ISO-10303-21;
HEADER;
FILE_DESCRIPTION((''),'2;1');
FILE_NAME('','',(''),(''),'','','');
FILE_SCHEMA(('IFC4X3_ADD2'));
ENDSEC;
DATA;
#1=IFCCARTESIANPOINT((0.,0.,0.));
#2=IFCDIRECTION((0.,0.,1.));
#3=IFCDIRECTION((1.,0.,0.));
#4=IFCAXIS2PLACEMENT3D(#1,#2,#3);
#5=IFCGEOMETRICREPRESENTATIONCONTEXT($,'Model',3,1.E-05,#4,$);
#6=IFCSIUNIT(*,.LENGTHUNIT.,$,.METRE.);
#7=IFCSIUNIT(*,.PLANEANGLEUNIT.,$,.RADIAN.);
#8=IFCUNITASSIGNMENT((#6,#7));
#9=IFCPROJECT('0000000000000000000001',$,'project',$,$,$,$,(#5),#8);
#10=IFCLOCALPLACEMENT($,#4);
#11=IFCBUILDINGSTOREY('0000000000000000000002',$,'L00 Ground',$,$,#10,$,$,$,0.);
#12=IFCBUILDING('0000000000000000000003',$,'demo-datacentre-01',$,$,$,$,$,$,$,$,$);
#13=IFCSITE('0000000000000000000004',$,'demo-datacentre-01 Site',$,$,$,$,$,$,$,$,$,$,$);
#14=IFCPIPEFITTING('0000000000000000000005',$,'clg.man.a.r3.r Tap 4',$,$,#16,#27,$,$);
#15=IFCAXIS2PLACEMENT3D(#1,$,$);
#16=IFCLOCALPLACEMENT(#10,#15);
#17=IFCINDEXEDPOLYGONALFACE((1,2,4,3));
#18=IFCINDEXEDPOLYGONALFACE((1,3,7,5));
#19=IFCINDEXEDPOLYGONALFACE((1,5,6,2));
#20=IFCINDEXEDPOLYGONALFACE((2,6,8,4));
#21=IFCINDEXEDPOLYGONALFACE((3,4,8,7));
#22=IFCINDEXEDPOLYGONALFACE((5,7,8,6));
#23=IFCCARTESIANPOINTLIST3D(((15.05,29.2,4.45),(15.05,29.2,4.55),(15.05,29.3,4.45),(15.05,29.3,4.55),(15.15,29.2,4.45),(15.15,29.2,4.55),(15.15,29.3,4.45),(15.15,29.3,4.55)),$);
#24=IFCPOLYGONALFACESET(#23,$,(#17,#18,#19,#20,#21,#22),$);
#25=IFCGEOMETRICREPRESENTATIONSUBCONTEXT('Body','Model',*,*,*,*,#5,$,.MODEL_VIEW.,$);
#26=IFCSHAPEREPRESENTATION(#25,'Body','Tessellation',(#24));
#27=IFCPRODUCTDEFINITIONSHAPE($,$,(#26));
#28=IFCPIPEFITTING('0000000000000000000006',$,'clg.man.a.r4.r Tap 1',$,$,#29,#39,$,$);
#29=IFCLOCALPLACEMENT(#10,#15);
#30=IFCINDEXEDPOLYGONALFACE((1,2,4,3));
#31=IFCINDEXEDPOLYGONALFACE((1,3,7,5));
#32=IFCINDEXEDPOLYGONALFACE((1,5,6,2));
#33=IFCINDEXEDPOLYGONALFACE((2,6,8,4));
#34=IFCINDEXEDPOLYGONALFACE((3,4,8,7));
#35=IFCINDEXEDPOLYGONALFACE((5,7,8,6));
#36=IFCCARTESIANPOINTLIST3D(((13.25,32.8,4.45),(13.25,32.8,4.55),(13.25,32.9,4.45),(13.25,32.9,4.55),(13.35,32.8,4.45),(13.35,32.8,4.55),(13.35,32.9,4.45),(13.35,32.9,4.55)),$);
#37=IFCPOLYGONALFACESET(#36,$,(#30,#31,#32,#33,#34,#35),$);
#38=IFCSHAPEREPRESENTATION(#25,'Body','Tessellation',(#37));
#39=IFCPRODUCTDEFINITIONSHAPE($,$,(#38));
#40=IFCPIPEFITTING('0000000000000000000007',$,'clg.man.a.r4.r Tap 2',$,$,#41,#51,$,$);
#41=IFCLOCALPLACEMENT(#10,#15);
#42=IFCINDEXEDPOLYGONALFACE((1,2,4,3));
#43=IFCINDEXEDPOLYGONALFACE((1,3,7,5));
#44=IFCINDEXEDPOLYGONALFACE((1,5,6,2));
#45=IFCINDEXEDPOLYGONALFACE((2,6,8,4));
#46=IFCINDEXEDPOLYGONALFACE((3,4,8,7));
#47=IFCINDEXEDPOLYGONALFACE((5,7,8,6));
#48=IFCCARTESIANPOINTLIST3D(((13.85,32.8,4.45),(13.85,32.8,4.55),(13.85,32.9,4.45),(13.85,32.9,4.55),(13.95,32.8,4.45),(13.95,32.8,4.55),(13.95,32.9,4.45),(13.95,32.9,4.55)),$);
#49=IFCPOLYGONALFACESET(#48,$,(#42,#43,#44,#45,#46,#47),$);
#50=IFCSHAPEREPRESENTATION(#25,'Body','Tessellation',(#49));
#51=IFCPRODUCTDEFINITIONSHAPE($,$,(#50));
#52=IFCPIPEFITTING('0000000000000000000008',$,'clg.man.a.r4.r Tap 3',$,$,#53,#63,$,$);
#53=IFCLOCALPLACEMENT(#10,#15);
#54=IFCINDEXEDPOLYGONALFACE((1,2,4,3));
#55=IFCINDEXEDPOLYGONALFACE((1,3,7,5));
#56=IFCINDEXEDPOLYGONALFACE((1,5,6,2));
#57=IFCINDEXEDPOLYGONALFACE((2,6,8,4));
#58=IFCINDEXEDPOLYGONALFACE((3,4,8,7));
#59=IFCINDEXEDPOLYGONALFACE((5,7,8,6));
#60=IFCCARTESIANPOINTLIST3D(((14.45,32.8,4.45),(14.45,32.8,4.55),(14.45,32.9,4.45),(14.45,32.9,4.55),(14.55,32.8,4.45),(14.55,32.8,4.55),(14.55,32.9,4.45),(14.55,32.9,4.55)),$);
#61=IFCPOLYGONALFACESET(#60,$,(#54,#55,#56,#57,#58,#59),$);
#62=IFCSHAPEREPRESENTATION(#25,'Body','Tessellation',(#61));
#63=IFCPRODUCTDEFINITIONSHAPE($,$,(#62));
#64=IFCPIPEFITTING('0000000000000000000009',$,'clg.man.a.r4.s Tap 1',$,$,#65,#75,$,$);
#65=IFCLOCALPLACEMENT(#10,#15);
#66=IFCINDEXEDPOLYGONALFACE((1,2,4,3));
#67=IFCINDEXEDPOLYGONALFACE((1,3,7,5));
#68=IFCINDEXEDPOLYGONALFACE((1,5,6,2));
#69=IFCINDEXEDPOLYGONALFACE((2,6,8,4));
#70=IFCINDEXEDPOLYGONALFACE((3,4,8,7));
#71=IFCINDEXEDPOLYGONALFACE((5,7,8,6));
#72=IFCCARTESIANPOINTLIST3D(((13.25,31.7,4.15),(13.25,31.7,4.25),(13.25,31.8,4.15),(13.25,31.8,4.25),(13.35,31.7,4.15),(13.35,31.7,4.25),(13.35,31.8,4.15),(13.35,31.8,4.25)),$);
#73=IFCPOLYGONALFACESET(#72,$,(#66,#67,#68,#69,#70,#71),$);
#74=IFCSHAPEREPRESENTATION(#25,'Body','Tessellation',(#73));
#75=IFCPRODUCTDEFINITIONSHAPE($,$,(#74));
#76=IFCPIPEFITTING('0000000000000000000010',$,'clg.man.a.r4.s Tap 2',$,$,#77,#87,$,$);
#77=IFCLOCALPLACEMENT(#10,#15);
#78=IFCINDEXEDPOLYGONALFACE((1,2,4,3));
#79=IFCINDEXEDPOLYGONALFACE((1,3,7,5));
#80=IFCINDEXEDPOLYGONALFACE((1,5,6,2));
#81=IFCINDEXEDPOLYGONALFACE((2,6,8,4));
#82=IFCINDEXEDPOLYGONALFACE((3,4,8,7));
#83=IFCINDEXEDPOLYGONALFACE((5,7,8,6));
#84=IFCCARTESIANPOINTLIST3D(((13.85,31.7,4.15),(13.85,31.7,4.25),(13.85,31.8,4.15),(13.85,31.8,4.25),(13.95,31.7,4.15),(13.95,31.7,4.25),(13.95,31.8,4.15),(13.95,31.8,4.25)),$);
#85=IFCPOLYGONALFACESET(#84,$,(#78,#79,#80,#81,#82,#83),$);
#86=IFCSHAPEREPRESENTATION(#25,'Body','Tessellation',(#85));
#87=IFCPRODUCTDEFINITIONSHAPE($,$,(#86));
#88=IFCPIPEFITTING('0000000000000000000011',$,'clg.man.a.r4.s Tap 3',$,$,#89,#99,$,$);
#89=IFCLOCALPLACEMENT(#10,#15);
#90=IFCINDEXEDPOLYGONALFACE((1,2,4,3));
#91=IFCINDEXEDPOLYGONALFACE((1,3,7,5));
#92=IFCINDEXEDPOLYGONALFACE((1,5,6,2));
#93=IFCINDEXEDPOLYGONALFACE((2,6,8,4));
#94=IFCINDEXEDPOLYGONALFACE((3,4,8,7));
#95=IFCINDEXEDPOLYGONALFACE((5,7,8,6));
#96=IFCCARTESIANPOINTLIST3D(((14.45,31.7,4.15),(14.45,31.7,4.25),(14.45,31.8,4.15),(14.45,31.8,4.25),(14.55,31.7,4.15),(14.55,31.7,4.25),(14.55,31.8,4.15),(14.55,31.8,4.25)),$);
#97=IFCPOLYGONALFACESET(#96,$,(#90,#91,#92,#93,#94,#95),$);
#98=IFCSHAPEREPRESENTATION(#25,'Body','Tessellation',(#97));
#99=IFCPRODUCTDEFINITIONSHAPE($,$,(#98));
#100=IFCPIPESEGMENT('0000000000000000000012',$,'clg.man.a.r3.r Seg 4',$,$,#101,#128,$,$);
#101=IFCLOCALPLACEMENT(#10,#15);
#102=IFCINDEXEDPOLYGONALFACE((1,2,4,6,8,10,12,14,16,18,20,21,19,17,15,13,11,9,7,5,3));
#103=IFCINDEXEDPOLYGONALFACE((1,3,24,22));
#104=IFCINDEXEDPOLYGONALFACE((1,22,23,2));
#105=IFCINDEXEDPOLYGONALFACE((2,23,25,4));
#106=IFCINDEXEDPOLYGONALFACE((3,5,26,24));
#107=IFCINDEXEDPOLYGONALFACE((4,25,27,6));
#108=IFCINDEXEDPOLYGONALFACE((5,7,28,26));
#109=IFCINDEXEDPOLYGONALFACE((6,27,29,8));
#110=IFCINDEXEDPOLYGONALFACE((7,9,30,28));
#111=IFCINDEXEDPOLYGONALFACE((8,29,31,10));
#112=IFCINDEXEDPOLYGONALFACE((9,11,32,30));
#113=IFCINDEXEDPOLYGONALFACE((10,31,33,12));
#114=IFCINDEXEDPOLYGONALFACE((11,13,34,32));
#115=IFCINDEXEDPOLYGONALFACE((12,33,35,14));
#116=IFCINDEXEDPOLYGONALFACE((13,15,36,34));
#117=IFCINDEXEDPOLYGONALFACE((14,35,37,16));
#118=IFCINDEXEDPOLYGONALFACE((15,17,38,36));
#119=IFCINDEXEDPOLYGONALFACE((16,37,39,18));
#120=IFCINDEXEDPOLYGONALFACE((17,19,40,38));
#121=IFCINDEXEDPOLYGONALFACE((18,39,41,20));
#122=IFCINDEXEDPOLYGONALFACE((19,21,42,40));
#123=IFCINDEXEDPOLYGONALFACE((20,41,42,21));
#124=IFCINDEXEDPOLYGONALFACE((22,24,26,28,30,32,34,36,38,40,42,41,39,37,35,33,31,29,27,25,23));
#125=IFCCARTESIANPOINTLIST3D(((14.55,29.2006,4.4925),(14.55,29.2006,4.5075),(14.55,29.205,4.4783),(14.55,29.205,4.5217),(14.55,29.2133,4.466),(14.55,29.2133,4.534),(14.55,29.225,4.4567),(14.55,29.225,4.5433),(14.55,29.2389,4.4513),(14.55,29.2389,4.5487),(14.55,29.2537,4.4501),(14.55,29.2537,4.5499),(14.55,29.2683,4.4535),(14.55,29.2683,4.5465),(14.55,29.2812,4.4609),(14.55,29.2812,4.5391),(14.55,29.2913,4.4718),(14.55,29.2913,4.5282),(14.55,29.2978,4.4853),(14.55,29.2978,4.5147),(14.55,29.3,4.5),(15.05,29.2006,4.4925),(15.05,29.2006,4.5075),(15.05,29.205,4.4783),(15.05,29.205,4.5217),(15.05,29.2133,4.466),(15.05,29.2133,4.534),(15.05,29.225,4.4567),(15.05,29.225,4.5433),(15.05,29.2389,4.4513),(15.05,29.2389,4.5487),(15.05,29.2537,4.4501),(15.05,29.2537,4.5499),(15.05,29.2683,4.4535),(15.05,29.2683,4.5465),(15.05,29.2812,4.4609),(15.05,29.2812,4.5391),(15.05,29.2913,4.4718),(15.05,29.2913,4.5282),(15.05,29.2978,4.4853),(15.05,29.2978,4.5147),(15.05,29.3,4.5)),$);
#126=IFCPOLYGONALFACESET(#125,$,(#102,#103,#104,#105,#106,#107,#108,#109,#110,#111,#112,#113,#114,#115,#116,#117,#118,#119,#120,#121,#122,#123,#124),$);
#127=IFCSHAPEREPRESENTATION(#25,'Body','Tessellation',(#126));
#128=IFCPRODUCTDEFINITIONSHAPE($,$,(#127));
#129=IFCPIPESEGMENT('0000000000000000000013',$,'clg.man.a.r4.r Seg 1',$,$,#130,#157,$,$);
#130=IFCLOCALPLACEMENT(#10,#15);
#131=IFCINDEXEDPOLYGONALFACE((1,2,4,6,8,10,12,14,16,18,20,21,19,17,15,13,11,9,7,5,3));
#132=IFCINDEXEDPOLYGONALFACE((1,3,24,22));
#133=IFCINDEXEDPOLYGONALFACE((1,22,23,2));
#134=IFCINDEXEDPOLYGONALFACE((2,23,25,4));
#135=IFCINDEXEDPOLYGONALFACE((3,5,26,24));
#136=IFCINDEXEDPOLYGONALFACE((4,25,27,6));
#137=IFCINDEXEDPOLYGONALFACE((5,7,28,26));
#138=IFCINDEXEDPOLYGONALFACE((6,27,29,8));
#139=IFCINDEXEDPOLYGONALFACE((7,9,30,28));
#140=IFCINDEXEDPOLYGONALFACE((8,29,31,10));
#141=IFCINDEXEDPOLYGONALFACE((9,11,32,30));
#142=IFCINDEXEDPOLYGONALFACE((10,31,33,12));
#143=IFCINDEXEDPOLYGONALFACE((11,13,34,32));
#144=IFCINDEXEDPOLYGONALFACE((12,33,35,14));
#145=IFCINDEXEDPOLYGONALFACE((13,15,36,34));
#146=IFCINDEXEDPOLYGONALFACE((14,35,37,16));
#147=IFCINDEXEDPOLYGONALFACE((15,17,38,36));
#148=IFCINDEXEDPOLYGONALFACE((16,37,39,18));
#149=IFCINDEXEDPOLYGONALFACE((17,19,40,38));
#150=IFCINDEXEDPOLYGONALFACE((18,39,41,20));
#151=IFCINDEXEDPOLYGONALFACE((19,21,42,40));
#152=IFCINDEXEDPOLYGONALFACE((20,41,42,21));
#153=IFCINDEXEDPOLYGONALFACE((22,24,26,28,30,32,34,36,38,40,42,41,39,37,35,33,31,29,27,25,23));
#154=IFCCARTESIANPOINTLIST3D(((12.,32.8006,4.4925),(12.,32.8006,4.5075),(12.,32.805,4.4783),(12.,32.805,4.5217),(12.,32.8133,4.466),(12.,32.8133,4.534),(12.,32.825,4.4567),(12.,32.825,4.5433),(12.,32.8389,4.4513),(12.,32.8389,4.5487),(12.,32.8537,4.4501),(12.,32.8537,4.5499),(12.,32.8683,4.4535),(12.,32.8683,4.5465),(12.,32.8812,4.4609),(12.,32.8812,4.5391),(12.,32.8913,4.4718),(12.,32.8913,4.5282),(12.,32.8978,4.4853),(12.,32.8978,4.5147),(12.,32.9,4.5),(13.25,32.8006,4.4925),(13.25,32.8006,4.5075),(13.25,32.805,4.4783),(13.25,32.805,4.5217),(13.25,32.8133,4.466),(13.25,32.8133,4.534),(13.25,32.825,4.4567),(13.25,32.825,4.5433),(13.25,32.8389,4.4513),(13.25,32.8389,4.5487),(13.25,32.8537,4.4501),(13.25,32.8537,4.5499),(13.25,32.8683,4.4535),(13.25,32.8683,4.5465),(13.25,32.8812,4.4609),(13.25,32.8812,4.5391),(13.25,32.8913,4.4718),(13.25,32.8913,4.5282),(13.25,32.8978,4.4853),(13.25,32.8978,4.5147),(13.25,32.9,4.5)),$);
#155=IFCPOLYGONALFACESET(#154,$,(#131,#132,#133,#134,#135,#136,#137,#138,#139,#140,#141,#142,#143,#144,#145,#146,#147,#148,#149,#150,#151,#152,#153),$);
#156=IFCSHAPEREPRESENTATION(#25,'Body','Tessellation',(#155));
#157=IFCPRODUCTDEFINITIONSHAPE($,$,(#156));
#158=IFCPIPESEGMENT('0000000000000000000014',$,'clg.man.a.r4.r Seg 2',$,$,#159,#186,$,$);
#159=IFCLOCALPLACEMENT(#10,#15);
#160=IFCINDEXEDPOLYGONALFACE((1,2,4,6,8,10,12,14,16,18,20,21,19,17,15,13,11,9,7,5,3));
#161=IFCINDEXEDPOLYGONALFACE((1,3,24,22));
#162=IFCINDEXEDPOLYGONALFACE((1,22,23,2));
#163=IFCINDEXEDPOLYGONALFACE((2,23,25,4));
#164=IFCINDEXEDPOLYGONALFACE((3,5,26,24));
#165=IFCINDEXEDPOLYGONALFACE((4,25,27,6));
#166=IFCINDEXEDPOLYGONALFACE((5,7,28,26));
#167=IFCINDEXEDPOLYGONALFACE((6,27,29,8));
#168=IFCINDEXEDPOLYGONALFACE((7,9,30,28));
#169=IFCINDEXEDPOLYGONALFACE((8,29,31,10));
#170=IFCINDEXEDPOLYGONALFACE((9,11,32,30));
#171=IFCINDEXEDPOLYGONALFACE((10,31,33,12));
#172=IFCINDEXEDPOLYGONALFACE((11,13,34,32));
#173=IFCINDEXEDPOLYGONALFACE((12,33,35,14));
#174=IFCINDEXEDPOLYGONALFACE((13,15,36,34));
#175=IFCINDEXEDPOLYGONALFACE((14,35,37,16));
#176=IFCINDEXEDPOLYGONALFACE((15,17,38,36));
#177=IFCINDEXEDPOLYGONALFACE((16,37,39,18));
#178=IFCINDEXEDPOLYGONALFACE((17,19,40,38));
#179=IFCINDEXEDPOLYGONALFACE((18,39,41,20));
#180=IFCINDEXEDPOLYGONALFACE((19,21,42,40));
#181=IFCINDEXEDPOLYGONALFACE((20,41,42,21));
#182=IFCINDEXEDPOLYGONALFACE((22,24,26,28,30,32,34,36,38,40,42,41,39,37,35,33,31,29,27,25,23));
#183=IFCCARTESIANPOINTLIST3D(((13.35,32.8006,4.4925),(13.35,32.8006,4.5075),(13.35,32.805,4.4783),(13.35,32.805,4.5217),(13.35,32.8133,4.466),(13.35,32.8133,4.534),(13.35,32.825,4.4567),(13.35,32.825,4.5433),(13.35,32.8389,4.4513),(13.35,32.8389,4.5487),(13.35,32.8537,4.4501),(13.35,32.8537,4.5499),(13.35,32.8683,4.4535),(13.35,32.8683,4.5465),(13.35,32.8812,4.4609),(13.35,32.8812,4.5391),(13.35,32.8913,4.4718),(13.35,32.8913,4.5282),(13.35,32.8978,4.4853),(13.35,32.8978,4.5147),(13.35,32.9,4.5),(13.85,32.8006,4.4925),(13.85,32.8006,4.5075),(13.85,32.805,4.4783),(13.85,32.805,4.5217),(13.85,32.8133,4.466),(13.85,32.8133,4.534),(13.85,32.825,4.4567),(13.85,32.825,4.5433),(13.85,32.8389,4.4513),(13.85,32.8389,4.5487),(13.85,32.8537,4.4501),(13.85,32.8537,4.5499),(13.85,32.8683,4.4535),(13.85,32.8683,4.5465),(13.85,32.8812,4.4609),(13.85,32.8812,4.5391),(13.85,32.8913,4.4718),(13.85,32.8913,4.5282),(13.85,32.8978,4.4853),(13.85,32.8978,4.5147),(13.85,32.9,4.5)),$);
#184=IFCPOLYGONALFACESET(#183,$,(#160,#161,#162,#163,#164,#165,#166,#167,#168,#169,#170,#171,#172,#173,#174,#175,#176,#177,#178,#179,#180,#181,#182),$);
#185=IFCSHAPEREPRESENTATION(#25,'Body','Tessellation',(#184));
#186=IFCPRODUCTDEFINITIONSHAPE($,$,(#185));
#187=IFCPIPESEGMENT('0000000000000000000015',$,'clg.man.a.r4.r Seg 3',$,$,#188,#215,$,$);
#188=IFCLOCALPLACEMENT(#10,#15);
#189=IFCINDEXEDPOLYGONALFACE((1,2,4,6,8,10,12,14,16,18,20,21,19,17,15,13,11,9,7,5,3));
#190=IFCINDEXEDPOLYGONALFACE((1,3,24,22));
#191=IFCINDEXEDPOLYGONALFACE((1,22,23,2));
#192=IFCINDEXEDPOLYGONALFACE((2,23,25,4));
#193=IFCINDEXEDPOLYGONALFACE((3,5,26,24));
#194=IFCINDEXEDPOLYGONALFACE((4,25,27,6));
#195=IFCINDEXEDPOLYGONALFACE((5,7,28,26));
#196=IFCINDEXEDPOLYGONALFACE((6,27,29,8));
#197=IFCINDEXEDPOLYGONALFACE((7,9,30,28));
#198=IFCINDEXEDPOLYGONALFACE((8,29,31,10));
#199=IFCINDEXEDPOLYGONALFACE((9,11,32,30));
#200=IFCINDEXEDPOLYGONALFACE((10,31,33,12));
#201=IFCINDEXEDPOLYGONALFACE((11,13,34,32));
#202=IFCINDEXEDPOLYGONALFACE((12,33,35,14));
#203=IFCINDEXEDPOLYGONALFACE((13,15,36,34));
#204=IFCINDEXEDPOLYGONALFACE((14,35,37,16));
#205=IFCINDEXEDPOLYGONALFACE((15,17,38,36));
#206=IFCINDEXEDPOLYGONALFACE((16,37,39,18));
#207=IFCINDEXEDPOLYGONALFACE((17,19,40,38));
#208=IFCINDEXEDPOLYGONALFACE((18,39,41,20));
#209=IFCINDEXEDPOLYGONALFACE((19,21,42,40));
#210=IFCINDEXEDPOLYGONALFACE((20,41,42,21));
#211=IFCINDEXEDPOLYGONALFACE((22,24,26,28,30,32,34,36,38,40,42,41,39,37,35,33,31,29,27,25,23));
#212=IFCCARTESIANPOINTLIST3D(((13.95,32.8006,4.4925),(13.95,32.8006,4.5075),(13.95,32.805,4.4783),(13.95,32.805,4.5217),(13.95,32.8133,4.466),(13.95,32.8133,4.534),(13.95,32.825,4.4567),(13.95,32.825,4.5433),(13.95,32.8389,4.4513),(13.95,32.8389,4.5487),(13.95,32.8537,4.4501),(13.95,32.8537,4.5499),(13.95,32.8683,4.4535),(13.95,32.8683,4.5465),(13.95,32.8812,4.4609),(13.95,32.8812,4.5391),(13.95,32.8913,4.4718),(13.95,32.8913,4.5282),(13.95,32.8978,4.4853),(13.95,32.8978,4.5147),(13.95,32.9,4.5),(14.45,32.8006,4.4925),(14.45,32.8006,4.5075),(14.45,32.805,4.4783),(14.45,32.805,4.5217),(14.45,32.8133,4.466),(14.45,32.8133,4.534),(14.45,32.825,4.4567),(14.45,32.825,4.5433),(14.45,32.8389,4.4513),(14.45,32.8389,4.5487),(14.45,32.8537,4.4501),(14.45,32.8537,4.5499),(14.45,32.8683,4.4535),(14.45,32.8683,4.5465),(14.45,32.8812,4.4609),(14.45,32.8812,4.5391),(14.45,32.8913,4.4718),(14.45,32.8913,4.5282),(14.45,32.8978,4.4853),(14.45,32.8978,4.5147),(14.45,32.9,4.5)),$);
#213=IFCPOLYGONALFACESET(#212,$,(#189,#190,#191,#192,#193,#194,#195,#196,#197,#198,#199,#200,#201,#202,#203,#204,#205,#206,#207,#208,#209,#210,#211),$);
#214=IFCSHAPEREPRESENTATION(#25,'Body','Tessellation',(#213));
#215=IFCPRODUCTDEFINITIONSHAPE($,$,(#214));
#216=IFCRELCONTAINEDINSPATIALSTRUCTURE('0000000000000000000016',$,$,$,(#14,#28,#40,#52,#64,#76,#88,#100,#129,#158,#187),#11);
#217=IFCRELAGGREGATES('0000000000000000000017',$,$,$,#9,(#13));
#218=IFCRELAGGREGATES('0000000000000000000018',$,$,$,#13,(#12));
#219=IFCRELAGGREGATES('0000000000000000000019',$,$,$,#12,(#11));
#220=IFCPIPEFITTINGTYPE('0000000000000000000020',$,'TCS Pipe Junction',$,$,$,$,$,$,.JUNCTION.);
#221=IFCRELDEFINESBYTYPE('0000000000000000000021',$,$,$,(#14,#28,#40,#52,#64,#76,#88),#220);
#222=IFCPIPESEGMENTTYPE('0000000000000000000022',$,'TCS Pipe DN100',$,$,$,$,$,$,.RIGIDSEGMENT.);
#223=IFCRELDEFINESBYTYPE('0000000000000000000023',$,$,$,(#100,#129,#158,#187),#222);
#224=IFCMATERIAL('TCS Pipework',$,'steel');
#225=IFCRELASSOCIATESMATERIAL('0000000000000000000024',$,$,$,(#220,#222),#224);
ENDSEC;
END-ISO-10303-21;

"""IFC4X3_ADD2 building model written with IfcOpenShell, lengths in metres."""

from ifc_helpers import new_model, si_unit, frame, origin_with_axes, place, context, subcontext, project, spatial, rectangle, circle, extrude, material, type_object, element, save


model = new_model("IFC4X3_ADD2")

# Units and contexts
model_context = context("Model", 3, precision=1e-05, world=origin_with_axes())
body_context = subcontext(model_context, "Body", "Model", "MODEL_VIEW")
ifc_project = project(units=[si_unit("LENGTHUNIT", "METRE"), si_unit("PLANEANGLEUNIT", "RADIAN")], contexts=[model_context])

# Site, building, storey
site = spatial("IfcSite", under=ifc_project, Name="demo-datacentre-01 Site")
building = spatial("IfcBuilding", under=site, Name="demo-datacentre-01")
storey_placement = place(None, origin_with_axes())
storey = spatial("IfcBuildingStorey", under=building, at=storey_placement, Name="L00 Ground", Elevation=0.0)

# Pipe fittings
ifc_material = material(Name="TCS Pipework", Category="steel")
pipe_fitting_type = type_object("IfcPipeFittingType", Name="TCS Pipe Junction", PredefinedType="JUNCTION", material=ifc_material)
for number, where, z_axis, x_axis, name in (
    (1, (15.1, 29.25, 4.45), (0.0, 0.0, 1.0), (1.0, 0.0, 0.0), "clg.man.a.r3.r Tap 4"),
    (2, (13.3, 32.85, 4.45), (0.0, 0.0, 1.0), (1.0, 0.0, 0.0), "clg.man.a.r4.r Tap 1"),
    (3, (13.9, 32.85, 4.45), (0.0, 0.0, 1.0), (1.0, 0.0, 0.0), "clg.man.a.r4.r Tap 2"),
    (4, (14.5, 32.85, 4.45), (0.0, 0.0, 1.0), (1.0, 0.0, 0.0), "clg.man.a.r4.r Tap 3"),
    (5, (13.3, 31.75, 4.15), (0.0, 0.0, 1.0), (1.0, 0.0, 0.0), "clg.man.a.r4.s Tap 1"),
    (6, (13.9, 31.75, 4.15), (0.0, 0.0, 1.0), (1.0, 0.0, 0.0), "clg.man.a.r4.s Tap 2"),
    (7, (14.5, 31.75, 4.15), (0.0, 0.0, 1.0), (1.0, 0.0, 0.0), "clg.man.a.r4.s Tap 3"),
):
    element("IfcPipeFitting", number, at=place(storey_placement, frame(where, z_axis=z_axis, x_axis=x_axis)), inside=storey, type_object=pipe_fitting_type, Name=name, context=body_context, shape_type="SweptSolid", body=[
        extrude(rectangle(XDim=0.1, YDim=0.1), origin_with_axes(), (0.0, 0.0, 1.0), 0.1),
    ])

# Pipe segments
pipe_segment_type_1 = type_object("IfcPipeSegmentType", Name="TCS Pipe DN100", PredefinedType="RIGIDSEGMENT", material=ifc_material)
pipe_segment_1_placement = place(storey_placement, frame((14.55, 29.25, 4.5), z_axis=(1.0, 0.0, 0.0), x_axis=(0.0, 1.0, 0.0)))
element("IfcPipeSegment", 8, at=pipe_segment_1_placement, inside=storey, type_object=pipe_segment_type_1, Name="clg.man.a.r3.r Seg 4", context=body_context, shape_type="SweptSolid", body=[
    extrude(circle(Radius=0.05), origin_with_axes(), (0.0, 0.0, 1.0), 0.5),
])
pipe_segment_2_placement = place(storey_placement, frame((12.0, 32.85, 4.5), z_axis=(1.0, 0.0, 0.0), x_axis=(0.0, 1.0, 0.0)))
element("IfcPipeSegment", 9, at=pipe_segment_2_placement, inside=storey, type_object=pipe_segment_type_1, Name="clg.man.a.r4.r Seg 1", context=body_context, shape_type="SweptSolid", body=[
    extrude(circle(Radius=0.05), origin_with_axes(), (0.0, 0.0, 1.0), 1.25),
])
for number, where, z_axis, x_axis, name in (
    (10, (13.35, 32.85, 4.5), (1.0, 0.0, 0.0), (0.0, 1.0, 0.0), "clg.man.a.r4.r Seg 2"),
    (11, (13.95, 32.85, 4.5), (1.0, 0.0, 0.0), (0.0, 1.0, 0.0), "clg.man.a.r4.r Seg 3"),
):
    element("IfcPipeSegment", number, at=place(storey_placement, frame(where, z_axis=z_axis, x_axis=x_axis)), inside=storey, type_object=pipe_segment_type_1, Name=name, context=body_context, shape_type="SweptSolid", body=[
        extrude(circle(Radius=0.05), origin_with_axes(), (0.0, 0.0, 1.0), 0.5),
    ])

save(model, "model.ifc")
